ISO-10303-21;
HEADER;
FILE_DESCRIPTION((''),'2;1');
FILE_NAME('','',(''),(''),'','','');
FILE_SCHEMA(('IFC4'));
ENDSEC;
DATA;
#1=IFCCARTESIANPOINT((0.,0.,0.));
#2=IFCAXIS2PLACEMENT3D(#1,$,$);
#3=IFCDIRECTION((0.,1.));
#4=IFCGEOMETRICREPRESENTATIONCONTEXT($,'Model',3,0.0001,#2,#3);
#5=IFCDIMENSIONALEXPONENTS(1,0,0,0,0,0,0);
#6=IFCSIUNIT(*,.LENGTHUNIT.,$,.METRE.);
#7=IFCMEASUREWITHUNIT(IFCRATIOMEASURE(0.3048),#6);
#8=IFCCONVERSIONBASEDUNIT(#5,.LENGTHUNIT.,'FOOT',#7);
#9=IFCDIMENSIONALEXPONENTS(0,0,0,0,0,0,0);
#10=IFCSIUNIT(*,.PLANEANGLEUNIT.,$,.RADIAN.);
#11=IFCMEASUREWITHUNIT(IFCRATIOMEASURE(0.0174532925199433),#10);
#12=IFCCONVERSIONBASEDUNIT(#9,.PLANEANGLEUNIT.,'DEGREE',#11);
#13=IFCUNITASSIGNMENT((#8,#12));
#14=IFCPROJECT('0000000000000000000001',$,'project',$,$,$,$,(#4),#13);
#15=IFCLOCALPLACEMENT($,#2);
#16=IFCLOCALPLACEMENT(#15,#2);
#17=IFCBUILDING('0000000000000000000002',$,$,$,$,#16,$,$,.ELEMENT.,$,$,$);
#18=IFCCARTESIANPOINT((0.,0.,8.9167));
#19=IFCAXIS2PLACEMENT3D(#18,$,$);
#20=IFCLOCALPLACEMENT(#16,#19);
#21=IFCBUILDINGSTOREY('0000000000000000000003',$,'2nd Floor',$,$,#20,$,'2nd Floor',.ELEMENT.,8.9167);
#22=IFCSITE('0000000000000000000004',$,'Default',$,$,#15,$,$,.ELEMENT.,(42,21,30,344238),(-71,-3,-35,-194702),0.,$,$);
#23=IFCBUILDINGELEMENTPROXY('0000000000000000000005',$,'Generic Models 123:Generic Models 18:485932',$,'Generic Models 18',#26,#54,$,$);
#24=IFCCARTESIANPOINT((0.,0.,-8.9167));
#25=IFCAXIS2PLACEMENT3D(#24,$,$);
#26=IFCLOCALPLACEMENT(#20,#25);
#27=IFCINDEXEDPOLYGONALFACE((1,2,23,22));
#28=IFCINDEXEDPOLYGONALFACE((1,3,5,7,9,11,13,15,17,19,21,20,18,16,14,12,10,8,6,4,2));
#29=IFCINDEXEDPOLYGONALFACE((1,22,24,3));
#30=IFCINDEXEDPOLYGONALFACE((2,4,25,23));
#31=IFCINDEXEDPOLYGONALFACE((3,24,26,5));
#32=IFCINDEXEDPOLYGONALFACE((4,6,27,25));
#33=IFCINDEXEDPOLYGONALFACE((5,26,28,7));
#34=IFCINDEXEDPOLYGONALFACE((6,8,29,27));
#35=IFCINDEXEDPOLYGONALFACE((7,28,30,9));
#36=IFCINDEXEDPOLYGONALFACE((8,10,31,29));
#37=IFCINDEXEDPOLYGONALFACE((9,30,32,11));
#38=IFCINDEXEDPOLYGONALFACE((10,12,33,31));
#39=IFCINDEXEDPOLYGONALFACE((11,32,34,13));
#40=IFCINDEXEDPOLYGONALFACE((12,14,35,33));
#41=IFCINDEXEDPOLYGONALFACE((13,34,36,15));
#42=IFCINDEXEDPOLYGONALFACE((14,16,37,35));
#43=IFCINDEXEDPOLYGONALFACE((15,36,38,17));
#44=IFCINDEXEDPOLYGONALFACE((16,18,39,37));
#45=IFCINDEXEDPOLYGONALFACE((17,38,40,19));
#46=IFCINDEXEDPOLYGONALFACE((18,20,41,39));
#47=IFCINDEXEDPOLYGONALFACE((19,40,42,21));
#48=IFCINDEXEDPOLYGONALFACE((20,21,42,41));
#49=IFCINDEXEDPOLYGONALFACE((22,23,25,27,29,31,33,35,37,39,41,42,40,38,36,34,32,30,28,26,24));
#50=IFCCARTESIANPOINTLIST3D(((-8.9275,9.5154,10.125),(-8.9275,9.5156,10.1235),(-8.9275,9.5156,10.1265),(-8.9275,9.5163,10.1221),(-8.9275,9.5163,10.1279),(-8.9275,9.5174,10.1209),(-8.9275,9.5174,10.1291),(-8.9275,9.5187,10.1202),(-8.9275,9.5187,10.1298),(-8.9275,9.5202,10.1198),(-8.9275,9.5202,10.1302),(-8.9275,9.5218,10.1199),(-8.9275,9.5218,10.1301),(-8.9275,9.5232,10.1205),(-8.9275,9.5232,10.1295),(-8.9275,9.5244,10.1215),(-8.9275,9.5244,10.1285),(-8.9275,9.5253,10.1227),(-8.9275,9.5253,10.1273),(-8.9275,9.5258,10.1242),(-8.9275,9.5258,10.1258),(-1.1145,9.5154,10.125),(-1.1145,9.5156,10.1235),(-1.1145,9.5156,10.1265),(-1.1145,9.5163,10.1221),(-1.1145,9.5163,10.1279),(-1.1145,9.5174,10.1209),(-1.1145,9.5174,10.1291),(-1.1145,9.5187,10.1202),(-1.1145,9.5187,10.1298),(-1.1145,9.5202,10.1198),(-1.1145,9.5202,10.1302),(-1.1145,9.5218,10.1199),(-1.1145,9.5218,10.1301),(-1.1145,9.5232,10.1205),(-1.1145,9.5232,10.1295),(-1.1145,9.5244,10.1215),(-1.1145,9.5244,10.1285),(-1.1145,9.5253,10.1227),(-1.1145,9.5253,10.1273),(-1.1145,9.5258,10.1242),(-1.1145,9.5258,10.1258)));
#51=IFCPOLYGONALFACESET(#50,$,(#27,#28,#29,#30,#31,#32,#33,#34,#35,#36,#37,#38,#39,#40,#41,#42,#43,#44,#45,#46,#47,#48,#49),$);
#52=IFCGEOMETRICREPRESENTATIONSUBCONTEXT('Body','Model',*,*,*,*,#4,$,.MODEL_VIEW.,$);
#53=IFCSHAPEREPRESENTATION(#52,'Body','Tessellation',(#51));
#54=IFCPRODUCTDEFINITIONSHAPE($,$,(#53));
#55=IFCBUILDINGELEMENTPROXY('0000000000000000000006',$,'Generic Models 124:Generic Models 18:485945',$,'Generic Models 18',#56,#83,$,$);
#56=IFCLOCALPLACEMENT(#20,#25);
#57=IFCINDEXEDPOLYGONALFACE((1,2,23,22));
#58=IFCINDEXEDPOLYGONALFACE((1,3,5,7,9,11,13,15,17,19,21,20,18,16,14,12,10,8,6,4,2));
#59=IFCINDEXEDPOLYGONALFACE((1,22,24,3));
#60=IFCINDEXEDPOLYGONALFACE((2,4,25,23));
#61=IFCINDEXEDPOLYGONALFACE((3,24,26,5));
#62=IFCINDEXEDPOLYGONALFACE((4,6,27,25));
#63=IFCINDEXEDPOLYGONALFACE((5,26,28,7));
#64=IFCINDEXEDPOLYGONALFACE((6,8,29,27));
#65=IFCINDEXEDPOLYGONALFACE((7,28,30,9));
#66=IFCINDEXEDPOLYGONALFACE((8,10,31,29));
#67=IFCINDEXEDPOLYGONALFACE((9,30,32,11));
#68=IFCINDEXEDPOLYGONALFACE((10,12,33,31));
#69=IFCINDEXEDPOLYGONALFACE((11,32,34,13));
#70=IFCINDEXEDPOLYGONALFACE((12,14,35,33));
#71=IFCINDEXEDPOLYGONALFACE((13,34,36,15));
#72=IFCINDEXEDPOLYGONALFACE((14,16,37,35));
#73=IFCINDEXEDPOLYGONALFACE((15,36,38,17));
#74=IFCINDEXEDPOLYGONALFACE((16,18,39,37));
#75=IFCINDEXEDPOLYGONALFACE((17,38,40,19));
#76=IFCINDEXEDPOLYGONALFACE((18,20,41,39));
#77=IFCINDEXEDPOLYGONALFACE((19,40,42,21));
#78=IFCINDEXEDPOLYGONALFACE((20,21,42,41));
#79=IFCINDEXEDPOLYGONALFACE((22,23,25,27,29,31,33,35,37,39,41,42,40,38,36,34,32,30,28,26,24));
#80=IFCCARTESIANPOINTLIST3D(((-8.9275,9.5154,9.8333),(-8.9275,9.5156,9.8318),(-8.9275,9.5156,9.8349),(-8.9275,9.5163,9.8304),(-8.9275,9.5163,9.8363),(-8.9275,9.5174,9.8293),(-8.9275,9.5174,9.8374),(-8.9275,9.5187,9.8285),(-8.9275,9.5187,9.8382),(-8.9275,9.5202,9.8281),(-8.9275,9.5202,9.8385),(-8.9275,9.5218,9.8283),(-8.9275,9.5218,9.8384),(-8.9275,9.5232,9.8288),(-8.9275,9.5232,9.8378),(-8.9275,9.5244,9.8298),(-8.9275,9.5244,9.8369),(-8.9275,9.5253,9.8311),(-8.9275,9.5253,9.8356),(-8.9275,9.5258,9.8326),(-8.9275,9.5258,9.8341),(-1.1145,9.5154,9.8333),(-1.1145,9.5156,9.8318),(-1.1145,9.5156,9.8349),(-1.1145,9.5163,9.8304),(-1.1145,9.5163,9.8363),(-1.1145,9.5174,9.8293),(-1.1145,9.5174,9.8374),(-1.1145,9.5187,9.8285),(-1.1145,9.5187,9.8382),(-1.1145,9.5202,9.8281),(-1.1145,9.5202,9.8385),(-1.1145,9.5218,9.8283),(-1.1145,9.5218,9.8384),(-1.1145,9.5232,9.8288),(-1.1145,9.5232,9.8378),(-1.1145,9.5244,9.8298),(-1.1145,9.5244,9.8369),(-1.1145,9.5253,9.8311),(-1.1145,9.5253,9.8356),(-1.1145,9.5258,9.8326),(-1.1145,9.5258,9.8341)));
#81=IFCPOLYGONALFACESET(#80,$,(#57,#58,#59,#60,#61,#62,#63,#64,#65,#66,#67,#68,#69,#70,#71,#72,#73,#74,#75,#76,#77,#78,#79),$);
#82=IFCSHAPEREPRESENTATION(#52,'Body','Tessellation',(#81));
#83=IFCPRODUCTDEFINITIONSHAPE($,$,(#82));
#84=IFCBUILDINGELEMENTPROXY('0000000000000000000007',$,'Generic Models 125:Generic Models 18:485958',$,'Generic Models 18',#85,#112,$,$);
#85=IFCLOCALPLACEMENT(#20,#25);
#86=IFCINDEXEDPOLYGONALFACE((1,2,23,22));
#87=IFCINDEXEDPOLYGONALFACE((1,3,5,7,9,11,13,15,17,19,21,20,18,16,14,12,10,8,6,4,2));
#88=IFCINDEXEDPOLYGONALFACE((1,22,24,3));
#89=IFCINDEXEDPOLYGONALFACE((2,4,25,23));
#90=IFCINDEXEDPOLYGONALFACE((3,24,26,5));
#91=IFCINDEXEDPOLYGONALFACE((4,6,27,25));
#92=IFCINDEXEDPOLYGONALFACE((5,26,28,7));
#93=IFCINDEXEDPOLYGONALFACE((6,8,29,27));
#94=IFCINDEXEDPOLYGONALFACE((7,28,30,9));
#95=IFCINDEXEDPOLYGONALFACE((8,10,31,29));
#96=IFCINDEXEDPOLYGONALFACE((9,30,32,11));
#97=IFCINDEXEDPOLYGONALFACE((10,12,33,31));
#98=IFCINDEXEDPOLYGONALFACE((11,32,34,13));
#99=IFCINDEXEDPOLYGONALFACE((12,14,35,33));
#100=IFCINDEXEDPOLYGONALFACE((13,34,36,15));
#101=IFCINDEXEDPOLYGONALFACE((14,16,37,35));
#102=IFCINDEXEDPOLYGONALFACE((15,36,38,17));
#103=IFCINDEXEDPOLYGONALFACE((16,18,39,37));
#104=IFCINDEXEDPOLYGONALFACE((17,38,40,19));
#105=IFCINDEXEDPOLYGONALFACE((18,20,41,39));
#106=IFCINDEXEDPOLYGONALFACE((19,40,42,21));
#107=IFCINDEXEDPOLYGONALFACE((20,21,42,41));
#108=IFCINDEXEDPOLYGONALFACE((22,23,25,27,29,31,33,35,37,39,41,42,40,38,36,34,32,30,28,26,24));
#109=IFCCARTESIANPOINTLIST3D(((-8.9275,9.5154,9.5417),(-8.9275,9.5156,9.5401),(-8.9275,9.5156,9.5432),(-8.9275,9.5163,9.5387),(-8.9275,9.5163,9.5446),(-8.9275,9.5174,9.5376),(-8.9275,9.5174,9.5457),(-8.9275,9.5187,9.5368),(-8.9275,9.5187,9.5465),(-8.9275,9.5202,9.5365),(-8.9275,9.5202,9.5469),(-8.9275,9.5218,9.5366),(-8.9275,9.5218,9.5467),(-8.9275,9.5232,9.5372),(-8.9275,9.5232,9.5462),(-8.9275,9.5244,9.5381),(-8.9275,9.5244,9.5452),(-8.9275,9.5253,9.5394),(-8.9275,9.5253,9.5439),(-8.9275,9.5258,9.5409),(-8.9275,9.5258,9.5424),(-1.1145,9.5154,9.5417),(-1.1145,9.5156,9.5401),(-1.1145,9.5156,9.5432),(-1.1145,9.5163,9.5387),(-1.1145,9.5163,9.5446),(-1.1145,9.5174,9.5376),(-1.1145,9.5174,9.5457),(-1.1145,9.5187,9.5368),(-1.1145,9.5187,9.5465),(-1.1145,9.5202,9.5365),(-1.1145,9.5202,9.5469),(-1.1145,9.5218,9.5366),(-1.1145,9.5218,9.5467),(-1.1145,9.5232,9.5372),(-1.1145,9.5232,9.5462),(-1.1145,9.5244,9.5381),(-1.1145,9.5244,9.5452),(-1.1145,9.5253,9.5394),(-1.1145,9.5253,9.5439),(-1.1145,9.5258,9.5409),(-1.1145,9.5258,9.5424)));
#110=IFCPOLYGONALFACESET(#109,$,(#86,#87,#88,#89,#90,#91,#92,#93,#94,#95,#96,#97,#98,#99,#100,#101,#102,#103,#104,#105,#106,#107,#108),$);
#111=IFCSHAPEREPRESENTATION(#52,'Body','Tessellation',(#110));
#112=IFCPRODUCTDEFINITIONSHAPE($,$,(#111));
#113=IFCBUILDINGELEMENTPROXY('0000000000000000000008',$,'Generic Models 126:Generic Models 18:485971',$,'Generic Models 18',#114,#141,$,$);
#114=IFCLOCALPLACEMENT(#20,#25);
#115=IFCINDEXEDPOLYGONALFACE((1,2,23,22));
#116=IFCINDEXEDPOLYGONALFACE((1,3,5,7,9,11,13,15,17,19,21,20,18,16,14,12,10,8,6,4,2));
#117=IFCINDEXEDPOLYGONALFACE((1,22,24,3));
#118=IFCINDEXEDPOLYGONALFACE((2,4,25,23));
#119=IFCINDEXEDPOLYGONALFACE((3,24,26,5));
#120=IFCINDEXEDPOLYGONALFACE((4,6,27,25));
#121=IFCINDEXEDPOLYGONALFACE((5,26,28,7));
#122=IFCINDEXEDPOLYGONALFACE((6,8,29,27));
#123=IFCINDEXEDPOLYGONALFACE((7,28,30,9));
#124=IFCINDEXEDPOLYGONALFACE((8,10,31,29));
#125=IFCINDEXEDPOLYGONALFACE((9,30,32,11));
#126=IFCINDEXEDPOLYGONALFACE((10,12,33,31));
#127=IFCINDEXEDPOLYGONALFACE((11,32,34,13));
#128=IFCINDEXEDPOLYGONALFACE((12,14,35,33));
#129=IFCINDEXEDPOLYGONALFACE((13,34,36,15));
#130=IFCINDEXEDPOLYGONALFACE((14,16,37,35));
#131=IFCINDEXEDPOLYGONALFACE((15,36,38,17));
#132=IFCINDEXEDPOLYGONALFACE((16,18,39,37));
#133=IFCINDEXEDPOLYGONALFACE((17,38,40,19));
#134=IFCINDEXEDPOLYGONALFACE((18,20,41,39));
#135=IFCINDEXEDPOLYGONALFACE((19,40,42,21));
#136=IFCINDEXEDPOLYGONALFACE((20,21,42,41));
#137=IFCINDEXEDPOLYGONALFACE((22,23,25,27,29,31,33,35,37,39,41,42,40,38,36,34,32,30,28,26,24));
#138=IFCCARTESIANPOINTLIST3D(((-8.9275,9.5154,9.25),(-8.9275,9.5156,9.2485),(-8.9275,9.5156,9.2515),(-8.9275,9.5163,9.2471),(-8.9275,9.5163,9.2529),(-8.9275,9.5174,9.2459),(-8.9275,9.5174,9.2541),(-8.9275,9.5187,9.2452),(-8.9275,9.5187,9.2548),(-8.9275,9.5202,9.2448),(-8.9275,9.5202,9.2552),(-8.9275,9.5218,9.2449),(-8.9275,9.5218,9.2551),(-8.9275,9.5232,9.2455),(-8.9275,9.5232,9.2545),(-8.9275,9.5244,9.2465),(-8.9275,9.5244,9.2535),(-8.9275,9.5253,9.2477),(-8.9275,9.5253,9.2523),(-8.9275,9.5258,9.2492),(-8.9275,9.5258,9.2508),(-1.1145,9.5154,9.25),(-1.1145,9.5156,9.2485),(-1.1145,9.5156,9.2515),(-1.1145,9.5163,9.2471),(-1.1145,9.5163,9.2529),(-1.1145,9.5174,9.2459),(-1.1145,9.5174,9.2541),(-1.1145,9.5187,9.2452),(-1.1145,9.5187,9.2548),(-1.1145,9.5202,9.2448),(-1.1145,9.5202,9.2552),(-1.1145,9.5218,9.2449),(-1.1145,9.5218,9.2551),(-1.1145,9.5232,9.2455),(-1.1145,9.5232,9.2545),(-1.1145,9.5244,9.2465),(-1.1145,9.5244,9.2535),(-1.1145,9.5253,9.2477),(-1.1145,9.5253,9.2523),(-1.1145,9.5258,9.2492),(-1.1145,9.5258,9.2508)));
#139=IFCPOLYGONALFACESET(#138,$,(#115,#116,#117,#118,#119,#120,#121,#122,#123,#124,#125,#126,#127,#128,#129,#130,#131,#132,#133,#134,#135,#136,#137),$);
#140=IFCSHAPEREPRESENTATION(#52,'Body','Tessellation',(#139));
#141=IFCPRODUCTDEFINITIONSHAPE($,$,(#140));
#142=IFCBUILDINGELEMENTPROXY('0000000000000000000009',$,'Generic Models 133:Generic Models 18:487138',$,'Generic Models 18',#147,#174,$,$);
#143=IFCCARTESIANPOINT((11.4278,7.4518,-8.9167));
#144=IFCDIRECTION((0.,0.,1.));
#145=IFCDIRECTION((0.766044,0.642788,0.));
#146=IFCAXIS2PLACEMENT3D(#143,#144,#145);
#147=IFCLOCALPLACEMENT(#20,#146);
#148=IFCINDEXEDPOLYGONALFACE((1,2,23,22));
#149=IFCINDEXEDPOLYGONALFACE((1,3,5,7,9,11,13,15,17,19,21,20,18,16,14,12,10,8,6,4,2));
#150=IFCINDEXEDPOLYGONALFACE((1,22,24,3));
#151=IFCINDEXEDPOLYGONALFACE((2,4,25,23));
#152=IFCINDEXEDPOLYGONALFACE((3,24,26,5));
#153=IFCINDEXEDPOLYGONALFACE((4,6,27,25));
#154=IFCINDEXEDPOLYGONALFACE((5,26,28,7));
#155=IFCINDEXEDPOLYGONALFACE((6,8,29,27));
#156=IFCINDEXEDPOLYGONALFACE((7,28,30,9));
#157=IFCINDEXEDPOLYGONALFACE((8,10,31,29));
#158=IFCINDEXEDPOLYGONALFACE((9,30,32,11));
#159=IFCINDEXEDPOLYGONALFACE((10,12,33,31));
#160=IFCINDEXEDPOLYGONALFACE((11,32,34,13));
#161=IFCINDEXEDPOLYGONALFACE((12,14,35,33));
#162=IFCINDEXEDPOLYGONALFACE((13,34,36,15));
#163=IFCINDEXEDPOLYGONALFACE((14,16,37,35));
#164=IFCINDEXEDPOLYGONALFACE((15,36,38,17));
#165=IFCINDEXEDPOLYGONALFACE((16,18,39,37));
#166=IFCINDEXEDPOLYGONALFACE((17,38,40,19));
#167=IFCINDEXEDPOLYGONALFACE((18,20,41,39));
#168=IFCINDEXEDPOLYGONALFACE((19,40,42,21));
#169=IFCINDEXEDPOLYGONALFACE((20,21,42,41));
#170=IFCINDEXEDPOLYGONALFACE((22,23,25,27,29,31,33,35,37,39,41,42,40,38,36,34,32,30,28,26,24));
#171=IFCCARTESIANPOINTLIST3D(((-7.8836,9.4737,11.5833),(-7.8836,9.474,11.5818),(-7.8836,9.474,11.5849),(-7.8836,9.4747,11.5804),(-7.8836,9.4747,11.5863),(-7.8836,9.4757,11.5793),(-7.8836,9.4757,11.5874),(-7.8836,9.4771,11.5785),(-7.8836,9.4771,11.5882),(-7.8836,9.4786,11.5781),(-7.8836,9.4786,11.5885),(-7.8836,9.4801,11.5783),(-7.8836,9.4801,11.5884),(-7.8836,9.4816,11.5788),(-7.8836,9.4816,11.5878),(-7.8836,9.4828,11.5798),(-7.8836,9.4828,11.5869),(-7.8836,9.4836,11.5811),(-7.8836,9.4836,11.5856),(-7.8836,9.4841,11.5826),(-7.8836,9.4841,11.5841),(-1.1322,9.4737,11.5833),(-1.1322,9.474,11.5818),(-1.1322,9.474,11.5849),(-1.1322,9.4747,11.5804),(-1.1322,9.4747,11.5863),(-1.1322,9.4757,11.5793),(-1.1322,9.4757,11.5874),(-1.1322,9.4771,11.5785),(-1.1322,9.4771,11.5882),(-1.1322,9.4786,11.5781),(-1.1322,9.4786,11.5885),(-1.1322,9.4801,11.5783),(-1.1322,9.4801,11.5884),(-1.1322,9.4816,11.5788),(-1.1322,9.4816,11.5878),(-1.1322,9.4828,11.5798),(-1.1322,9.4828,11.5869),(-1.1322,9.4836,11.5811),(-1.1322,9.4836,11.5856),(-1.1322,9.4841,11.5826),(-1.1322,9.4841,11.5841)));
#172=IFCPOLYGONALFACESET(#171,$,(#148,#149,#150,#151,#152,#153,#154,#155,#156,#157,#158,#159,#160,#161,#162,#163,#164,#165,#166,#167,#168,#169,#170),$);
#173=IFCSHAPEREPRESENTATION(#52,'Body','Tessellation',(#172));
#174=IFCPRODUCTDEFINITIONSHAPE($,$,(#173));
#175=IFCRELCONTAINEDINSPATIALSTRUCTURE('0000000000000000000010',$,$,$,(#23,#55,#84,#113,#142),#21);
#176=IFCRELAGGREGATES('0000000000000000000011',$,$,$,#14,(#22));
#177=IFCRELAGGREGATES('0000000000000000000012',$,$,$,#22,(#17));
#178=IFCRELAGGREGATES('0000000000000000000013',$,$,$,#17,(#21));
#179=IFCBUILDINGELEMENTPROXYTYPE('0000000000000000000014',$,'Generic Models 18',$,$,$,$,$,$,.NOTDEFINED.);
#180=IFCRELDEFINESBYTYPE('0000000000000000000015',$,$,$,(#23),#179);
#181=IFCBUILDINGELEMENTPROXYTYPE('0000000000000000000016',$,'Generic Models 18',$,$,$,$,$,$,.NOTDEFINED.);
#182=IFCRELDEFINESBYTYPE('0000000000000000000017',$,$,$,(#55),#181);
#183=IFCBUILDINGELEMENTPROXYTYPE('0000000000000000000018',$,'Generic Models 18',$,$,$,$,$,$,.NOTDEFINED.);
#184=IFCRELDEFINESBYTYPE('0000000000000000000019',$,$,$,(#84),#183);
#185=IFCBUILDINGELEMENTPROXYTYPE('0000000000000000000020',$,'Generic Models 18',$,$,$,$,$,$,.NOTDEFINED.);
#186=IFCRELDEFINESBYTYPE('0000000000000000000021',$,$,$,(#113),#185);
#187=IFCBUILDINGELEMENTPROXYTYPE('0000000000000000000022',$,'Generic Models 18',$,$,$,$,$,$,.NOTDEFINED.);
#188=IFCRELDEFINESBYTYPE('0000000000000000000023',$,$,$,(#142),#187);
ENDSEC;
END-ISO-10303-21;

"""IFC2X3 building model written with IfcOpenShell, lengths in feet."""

from ifc_helpers import new_model, entity, si_unit, converted_unit, direction, frame, origin, origin_2d_with_axis, place, context, subcontext, project, spatial, circle, extrude, source, transform, mapped, type_object, type_shapes, element, save


model = new_model("IFC2X3")

# Units and contexts
model_context = context("Model", 3, precision=0.0001, world=origin(), true_north=direction((0.0, 1.0)))
body_context = subcontext(model_context, "Body", "Model", "MODEL_VIEW")
ifc_project = project(units=[converted_unit("LENGTHUNIT", "FOOT", entity("IfcRatioMeasure", 0.3048), si_unit("LENGTHUNIT", "METRE"), dimensions=[1, 0, 0, 0, 0, 0, 0]), converted_unit("PLANEANGLEUNIT", "DEGREE", entity("IfcRatioMeasure", 0.0174532925199433), si_unit("PLANEANGLEUNIT", "RADIAN"), dimensions=[0, 0, 0, 0, 0, 0, 0])], contexts=[model_context])

# Site, building, storey
site_placement = place(None, origin())
site = spatial("IfcSite", under=ifc_project, at=site_placement, Name="Default", CompositionType="ELEMENT", RefLatitude=(42, 21, 30, 344238), RefLongitude=(-71, -3, -35, -194702), RefElevation=0.0)
building_placement = place(site_placement, origin())
building = spatial("IfcBuilding", under=site, at=building_placement, CompositionType="ELEMENT")
storey_placement = place(building_placement, frame((0.0, 0.0, 8.9167)))
storey = spatial("IfcBuildingStorey", under=building, at=storey_placement, Name="2nd Floor", LongName="2nd Floor", CompositionType="ELEMENT", Elevation=8.9167)

# Building element proxies
building_element_proxy_type_1 = type_object("IfcBuildingElementProxyType", Name="Generic Models 18", PredefinedType="NOTDEFINED")
shared_shape_1 = source(origin(), body_context, "Body", "SweptSolid", [
    extrude(circle(Radius=0.0052, at=origin_2d_with_axis()), frame((-8.9275, 9.5206, 10.125), z_axis=(1.0, 0.0, 0.0), x_axis=(0.0, -1.0, 0.0)), (0.0, 0.0, 1.0), 7.813),
])
type_shapes(building_element_proxy_type_1, [shared_shape_1])
proxy_1_placement = place(storey_placement, frame((0.0, 0.0, -8.9167)))
element("IfcBuildingElementProxy", 1, at=proxy_1_placement, inside=storey, type_object=building_element_proxy_type_1, Name="Generic Models 123:Generic Models 18:485932", ObjectType="Generic Models 18", context=body_context, shape_type="MappedRepresentation", body=[
    mapped(shared_shape_1, transform((0.0, 0.0, 0.0), scale=1.0)),
])
building_element_proxy_type_2 = type_object("IfcBuildingElementProxyType", Name="Generic Models 18", PredefinedType="NOTDEFINED")
shared_shape_2 = source(origin(), body_context, "Body", "SweptSolid", [
    extrude(circle(Radius=0.0052, at=origin_2d_with_axis()), frame((-8.9275, 9.5206, 9.8333), z_axis=(1.0, 0.0, 0.0), x_axis=(0.0, -1.0, 0.0)), (0.0, 0.0, 1.0), 7.813),
])
type_shapes(building_element_proxy_type_2, [shared_shape_2])
proxy_2_placement = place(storey_placement, frame((0.0, 0.0, -8.9167)))
element("IfcBuildingElementProxy", 2, at=proxy_2_placement, inside=storey, type_object=building_element_proxy_type_2, Name="Generic Models 124:Generic Models 18:485945", ObjectType="Generic Models 18", context=body_context, shape_type="MappedRepresentation", body=[
    mapped(shared_shape_2, transform((0.0, 0.0, 0.0), scale=1.0)),
])
building_element_proxy_type_3 = type_object("IfcBuildingElementProxyType", Name="Generic Models 18", PredefinedType="NOTDEFINED")
shared_shape_3 = source(origin(), body_context, "Body", "SweptSolid", [
    extrude(circle(Radius=0.0052, at=origin_2d_with_axis()), frame((-8.9275, 9.5206, 9.5417), z_axis=(1.0, 0.0, 0.0), x_axis=(0.0, -1.0, 0.0)), (0.0, 0.0, 1.0), 7.813),
])
type_shapes(building_element_proxy_type_3, [shared_shape_3])
proxy_3_placement = place(storey_placement, frame((0.0, 0.0, -8.9167)))
element("IfcBuildingElementProxy", 3, at=proxy_3_placement, inside=storey, type_object=building_element_proxy_type_3, Name="Generic Models 125:Generic Models 18:485958", ObjectType="Generic Models 18", context=body_context, shape_type="MappedRepresentation", body=[
    mapped(shared_shape_3, transform((0.0, 0.0, 0.0), scale=1.0)),
])
building_element_proxy_type_4 = type_object("IfcBuildingElementProxyType", Name="Generic Models 18", PredefinedType="NOTDEFINED")
shared_shape_4 = source(origin(), body_context, "Body", "SweptSolid", [
    extrude(circle(Radius=0.0052, at=origin_2d_with_axis()), frame((-8.9275, 9.5206, 9.25), z_axis=(1.0, 0.0, 0.0), x_axis=(0.0, -1.0, 0.0)), (0.0, 0.0, 1.0), 7.813),
])
type_shapes(building_element_proxy_type_4, [shared_shape_4])
proxy_4_placement = place(storey_placement, frame((0.0, 0.0, -8.9167)))
element("IfcBuildingElementProxy", 4, at=proxy_4_placement, inside=storey, type_object=building_element_proxy_type_4, Name="Generic Models 126:Generic Models 18:485971", ObjectType="Generic Models 18", context=body_context, shape_type="MappedRepresentation", body=[
    mapped(shared_shape_4, transform((0.0, 0.0, 0.0), scale=1.0)),
])
building_element_proxy_type_5 = type_object("IfcBuildingElementProxyType", Name="Generic Models 18", PredefinedType="NOTDEFINED")
shared_shape_5 = source(origin(), body_context, "Body", "SweptSolid", [
    extrude(circle(Radius=0.0052, at=origin_2d_with_axis()), frame((-7.8836, 9.479, 11.5833), z_axis=(1.0, 0.0, 0.0), x_axis=(0.0, -1.0, 0.0)), (0.0, 0.0, 1.0), 6.7514),
])
type_shapes(building_element_proxy_type_5, [shared_shape_5])
proxy_5_placement = place(storey_placement, frame((11.4278, 7.4518, -8.9167), z_axis=(0.0, 0.0, 1.0), x_axis=(0.766044, 0.642788, 0.0)))
element("IfcBuildingElementProxy", 5, at=proxy_5_placement, inside=storey, type_object=building_element_proxy_type_5, Name="Generic Models 133:Generic Models 18:487138", ObjectType="Generic Models 18", context=body_context, shape_type="MappedRepresentation", body=[
    mapped(shared_shape_5, transform((0.0, 0.0, 0.0), scale=1.0)),
])

save(model, "model.ifc")
